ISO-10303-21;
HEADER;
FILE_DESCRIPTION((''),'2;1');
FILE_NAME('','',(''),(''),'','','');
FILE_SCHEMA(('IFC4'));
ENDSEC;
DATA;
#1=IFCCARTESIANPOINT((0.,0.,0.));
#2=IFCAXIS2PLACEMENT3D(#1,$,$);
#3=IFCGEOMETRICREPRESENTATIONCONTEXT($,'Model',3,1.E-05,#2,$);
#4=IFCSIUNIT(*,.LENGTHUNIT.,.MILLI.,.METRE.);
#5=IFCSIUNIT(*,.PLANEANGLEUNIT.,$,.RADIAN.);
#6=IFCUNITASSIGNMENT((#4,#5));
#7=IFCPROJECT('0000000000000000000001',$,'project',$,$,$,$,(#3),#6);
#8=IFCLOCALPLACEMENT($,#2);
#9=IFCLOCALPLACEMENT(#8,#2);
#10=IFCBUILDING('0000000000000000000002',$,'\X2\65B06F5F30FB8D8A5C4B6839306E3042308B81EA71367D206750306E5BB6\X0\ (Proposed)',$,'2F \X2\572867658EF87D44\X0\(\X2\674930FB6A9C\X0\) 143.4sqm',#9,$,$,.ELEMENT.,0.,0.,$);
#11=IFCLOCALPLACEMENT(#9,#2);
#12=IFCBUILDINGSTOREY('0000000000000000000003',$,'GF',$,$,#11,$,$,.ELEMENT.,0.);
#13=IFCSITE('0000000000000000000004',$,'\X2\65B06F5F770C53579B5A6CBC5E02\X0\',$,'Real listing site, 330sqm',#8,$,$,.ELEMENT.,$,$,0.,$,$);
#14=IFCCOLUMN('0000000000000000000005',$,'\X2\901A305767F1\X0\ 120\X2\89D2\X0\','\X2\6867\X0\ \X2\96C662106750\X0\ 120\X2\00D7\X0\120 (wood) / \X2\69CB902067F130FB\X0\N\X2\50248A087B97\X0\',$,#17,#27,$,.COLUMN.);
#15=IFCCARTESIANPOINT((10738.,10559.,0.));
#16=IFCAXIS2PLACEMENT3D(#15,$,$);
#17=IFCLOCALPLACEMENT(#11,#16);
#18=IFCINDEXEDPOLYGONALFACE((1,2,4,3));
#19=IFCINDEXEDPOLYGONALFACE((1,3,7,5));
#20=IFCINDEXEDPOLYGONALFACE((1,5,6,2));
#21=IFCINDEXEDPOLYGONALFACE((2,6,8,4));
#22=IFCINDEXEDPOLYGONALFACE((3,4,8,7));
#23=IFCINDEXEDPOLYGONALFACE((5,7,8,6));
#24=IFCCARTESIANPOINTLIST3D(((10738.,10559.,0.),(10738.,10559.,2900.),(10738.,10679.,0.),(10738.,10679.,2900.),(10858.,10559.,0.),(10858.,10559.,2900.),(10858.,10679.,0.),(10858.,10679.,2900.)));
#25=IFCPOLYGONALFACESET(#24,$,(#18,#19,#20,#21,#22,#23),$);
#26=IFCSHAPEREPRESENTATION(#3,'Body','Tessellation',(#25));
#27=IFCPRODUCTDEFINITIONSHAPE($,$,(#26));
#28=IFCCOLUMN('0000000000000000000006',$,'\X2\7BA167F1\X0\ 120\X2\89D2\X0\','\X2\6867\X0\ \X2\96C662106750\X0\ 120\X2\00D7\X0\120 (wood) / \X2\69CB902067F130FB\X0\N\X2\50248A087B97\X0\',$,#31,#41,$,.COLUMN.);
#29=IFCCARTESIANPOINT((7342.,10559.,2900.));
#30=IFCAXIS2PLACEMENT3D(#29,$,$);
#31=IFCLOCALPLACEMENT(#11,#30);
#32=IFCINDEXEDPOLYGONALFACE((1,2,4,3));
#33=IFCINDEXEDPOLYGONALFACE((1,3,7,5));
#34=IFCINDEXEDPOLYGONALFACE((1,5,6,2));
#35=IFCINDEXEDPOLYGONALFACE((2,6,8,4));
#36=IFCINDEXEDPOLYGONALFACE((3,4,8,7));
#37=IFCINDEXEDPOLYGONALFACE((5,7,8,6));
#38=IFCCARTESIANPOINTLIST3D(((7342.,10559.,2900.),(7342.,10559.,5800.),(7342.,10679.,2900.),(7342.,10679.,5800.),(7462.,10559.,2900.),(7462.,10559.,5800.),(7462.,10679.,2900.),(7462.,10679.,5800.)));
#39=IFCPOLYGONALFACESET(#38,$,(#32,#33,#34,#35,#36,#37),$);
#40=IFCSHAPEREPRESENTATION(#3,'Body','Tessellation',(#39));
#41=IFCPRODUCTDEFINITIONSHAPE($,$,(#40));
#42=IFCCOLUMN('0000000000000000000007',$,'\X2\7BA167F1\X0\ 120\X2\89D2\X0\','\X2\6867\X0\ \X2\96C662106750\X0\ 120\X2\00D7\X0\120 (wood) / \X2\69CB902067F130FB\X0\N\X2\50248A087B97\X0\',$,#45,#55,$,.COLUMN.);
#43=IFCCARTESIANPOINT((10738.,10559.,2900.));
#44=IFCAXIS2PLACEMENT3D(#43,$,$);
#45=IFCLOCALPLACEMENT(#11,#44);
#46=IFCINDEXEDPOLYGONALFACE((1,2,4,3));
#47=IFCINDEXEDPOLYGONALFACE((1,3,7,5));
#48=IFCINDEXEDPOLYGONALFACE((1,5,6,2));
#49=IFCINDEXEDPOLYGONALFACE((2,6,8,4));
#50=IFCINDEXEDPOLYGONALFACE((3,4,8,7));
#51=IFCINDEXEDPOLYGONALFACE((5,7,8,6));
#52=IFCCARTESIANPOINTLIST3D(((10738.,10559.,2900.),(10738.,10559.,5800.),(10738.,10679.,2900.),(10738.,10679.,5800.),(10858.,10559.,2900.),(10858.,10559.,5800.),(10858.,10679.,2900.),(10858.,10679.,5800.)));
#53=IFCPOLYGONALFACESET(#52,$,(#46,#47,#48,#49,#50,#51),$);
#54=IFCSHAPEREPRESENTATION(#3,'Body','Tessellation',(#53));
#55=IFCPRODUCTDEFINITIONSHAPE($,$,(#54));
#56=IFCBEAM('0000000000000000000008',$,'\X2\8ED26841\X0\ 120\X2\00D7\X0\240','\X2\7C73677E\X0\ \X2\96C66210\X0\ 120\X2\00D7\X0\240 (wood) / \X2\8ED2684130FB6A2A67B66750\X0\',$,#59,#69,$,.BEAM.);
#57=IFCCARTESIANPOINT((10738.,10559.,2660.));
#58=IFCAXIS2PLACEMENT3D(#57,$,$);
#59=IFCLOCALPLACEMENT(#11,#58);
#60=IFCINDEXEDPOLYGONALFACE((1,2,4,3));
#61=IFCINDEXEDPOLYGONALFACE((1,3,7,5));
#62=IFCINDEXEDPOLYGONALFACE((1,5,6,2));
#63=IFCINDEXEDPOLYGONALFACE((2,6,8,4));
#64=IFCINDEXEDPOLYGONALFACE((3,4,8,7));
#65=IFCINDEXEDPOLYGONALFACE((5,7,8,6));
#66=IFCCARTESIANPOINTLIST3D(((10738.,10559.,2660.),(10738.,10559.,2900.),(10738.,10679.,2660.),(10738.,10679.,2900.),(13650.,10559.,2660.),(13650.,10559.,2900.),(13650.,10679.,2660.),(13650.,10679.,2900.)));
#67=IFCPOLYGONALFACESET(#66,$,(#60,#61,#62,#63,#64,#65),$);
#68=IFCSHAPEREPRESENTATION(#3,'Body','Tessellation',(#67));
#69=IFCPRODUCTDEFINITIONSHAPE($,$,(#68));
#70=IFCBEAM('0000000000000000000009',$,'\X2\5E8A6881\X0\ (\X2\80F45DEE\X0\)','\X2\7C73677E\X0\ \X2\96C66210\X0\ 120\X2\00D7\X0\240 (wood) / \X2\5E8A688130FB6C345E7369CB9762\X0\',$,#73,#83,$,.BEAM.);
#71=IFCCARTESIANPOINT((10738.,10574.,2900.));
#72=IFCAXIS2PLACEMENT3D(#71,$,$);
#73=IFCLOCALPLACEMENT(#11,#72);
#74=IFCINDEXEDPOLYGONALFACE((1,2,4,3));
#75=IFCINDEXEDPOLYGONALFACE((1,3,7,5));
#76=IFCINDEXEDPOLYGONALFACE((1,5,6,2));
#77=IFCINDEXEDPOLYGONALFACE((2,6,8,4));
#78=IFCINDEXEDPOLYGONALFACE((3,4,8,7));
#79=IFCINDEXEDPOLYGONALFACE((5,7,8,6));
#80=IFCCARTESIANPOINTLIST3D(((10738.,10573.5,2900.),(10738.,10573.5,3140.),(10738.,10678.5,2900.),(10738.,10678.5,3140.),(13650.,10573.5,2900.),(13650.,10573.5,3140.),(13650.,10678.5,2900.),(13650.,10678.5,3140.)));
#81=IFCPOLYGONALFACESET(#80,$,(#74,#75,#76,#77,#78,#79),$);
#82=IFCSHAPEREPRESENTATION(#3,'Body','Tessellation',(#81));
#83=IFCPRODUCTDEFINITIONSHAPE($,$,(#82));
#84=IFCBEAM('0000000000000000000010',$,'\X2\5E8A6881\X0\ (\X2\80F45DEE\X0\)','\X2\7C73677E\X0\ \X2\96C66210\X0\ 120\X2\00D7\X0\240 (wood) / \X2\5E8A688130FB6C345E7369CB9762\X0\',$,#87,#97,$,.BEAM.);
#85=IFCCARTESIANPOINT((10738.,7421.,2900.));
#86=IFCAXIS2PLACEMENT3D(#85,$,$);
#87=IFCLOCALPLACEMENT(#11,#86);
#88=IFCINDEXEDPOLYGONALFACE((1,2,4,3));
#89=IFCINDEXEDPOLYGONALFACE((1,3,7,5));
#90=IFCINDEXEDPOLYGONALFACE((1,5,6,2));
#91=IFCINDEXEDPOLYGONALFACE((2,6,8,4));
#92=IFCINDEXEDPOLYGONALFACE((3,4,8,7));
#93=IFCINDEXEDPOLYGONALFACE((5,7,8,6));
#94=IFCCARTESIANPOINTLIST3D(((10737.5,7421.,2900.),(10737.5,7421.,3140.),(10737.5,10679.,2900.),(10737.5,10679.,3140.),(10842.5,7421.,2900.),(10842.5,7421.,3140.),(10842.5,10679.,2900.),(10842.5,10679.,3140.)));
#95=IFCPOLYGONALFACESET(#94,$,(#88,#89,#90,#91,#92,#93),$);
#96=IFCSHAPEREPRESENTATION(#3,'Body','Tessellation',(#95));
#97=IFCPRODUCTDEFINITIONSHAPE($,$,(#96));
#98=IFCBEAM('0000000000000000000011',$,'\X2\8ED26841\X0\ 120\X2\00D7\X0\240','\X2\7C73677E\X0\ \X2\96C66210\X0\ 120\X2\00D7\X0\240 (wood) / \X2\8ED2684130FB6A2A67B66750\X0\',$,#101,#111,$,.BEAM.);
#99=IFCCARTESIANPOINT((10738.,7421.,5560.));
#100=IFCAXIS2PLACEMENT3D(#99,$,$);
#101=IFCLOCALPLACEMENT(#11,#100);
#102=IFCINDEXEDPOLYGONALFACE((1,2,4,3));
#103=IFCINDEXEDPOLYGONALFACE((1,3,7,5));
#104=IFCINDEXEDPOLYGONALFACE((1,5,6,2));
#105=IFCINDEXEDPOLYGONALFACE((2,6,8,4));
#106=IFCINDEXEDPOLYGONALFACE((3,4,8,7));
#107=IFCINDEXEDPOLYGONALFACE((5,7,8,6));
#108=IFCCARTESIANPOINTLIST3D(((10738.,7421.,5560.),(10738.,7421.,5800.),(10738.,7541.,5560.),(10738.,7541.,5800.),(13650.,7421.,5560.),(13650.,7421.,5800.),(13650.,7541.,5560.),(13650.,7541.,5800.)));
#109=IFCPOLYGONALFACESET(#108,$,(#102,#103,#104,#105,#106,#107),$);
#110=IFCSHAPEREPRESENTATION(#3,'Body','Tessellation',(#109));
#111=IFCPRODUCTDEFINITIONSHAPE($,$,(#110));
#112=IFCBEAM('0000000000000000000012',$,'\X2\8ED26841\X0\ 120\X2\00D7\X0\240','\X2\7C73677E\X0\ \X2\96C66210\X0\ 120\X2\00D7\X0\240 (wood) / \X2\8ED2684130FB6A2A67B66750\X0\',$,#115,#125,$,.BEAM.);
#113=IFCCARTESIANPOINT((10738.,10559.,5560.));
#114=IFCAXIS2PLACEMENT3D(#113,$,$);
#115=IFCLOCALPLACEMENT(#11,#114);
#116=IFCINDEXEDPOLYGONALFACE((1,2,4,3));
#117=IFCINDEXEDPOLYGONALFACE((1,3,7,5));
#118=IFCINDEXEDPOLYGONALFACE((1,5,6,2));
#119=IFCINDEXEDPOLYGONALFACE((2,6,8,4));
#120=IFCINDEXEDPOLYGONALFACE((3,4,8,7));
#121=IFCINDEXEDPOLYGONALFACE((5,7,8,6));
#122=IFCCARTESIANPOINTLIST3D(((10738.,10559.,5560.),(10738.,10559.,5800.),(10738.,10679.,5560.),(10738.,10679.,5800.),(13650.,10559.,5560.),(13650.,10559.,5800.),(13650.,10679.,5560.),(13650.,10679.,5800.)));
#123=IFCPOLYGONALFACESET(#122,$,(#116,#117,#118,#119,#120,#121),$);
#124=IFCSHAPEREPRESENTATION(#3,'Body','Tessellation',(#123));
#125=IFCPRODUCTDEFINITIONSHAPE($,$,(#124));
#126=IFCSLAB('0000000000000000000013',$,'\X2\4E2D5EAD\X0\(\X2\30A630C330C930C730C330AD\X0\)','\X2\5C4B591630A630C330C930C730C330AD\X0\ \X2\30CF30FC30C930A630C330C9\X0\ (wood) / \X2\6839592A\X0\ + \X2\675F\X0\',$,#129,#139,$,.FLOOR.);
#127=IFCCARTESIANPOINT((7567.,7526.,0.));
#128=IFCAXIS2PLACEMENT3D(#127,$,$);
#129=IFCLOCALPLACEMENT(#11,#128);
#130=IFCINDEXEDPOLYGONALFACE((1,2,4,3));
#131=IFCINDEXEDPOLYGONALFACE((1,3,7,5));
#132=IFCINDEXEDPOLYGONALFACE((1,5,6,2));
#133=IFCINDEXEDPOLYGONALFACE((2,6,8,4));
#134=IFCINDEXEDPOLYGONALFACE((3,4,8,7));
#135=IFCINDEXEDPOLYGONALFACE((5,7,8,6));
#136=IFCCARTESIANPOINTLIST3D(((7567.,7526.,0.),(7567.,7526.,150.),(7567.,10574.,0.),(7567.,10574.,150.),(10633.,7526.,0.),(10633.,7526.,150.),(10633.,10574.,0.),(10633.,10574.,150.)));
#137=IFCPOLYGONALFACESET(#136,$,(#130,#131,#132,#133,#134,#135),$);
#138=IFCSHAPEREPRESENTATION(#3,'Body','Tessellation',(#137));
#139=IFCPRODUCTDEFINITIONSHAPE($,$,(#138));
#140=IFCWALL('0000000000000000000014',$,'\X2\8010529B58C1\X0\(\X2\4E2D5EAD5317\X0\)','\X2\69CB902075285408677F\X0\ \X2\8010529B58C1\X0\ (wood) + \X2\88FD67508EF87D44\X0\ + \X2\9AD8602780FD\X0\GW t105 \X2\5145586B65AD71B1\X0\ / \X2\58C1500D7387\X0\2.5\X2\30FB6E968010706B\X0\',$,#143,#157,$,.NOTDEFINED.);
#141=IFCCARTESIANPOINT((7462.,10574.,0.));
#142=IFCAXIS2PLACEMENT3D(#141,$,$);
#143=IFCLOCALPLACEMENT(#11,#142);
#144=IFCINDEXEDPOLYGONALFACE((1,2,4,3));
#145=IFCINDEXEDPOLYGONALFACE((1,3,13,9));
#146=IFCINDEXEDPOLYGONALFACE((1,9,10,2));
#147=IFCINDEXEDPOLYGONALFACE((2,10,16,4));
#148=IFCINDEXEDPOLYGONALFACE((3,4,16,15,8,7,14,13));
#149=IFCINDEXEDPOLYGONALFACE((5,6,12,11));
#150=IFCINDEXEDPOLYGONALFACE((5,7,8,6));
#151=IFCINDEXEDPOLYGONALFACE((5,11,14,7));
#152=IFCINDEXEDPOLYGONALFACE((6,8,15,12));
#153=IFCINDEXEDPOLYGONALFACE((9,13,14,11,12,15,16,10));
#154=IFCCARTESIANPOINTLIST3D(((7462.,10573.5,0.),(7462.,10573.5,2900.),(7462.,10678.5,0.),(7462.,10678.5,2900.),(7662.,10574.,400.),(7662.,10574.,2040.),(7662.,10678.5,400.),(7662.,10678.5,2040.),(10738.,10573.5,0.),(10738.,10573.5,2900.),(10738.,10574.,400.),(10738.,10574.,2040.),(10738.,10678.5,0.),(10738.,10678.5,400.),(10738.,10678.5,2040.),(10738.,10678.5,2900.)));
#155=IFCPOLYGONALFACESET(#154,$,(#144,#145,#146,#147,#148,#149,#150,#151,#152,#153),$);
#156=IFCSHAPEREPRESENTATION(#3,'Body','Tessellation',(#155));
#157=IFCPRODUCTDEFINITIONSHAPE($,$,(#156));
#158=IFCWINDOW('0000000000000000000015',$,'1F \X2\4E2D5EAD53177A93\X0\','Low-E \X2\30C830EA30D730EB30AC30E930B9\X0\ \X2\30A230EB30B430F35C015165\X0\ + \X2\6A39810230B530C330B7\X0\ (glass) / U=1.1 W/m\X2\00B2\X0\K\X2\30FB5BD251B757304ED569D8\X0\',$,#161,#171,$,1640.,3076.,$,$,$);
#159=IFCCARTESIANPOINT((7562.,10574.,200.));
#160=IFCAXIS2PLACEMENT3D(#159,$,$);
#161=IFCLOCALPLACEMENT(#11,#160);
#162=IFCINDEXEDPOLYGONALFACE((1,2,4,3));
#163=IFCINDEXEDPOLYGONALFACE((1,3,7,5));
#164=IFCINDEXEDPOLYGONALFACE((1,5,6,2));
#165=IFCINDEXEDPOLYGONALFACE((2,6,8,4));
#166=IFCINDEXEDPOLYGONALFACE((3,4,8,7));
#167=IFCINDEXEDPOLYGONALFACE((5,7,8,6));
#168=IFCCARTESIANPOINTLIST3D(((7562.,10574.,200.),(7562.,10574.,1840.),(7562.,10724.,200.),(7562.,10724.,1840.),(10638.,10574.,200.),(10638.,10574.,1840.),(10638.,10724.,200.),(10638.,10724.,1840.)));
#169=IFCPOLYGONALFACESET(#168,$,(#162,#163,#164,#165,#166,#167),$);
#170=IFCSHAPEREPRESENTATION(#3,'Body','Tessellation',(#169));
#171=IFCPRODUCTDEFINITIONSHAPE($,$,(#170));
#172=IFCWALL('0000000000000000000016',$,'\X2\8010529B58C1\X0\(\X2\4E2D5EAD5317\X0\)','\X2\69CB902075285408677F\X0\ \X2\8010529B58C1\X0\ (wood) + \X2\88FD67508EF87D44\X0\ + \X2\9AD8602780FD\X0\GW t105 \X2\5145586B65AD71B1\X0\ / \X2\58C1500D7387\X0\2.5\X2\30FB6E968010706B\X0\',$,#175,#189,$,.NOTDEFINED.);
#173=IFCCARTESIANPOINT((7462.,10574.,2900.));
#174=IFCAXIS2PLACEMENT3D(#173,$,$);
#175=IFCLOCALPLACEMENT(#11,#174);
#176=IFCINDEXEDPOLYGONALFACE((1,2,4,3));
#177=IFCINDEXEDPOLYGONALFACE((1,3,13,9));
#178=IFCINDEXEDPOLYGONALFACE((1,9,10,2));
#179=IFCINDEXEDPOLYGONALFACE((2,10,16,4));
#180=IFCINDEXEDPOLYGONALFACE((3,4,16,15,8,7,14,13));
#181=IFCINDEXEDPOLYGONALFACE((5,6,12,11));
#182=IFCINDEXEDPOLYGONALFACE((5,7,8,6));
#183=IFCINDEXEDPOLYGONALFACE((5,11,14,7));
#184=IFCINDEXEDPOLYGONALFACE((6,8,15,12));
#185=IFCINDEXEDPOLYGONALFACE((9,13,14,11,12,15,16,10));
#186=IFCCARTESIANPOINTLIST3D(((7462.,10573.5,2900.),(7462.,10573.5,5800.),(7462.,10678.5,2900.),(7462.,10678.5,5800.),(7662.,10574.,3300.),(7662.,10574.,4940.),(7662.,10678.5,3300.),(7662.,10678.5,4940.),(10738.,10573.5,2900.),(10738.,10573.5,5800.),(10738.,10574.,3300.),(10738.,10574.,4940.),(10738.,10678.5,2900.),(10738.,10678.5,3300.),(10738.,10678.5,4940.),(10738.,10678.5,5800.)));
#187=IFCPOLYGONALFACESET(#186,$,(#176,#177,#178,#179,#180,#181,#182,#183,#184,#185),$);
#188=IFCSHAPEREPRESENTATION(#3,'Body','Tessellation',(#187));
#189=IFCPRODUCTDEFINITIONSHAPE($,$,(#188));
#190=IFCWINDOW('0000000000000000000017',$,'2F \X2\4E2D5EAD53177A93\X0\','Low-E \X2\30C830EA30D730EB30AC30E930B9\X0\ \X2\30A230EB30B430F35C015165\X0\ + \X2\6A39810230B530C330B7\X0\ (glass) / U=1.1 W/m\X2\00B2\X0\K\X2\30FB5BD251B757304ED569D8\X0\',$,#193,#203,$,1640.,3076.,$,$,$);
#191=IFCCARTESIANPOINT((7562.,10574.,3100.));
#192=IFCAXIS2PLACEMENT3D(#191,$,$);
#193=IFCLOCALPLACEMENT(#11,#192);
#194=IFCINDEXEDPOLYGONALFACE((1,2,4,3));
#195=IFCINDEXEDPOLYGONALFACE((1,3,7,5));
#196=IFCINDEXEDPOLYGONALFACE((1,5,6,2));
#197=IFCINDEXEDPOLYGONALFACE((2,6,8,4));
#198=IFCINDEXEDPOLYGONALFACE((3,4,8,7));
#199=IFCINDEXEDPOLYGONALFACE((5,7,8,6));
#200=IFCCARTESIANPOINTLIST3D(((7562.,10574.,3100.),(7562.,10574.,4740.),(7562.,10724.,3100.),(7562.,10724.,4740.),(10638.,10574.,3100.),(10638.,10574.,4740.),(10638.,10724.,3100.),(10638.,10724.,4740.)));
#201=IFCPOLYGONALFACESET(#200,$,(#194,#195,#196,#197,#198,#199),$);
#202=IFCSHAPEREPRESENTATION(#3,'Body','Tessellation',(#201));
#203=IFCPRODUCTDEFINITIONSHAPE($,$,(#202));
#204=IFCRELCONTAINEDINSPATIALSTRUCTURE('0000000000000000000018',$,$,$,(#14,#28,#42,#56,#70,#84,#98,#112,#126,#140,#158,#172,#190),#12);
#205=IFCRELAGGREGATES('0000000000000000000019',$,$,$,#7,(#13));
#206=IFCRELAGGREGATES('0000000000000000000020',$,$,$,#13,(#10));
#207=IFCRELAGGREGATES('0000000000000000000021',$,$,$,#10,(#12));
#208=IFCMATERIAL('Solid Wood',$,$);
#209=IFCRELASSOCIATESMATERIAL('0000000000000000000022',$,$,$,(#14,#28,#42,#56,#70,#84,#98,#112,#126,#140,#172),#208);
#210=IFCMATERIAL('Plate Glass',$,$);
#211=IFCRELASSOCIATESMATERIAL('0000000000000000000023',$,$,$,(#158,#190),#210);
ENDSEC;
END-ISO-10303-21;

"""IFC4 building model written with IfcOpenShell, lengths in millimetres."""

from ifc_helpers import new_model, si_unit, frame, frame_2d, origin, place, context, project, spatial, rectangle, extrude, material, element, fill, save


model = new_model("IFC4")

# Units and contexts
model_context = context("Model", 3, precision=1e-05, world=origin())
ifc_project = project(units=[si_unit("LENGTHUNIT", "METRE", prefix="MILLI"), si_unit("PLANEANGLEUNIT", "RADIAN")], contexts=[model_context])

# Site, building, storey
site_placement = place(None, origin())
site = spatial("IfcSite", under=ifc_project, at=site_placement, Name="新潟県南魚沼市", ObjectType="Real listing site, 330sqm", CompositionType="ELEMENT", RefElevation=0.0)
building_placement = place(site_placement, origin())
building = spatial("IfcBuilding", under=site, at=building_placement, Name="新潟・越屋根のある自然素材の家 (Proposed)", ObjectType="2F 在来軸組(杉・檜) 143.4sqm", CompositionType="ELEMENT", ElevationOfRefHeight=0.0, ElevationOfTerrain=0.0)
storey_placement = place(building_placement, origin())
storey = spatial("IfcBuildingStorey", under=building, at=storey_placement, Name="GF", CompositionType="ELEMENT", Elevation=0.0)

# Columns
ifc_material_1 = material(Name="Solid Wood")
column_1_placement = place(storey_placement, frame((10738.0, 10559.0, 0.0)))
element("IfcColumn", 1, at=column_1_placement, inside=storey, material=ifc_material_1, Name="通し柱 120角", Description="桧 集成材 120×120 (wood) / 構造柱・N値計算", PredefinedType="COLUMN", context=model_context, shape_type="SweptSolid", body=[
    extrude(rectangle(XDim=120.0, YDim=120.0, at=frame_2d((60.0, 60.0))), frame((10738.0, 10559.0, 0.0)), (0.0, 0.0, 1.0), 2900.0),
])
column_2_placement = place(storey_placement, frame((7342.0, 10559.0, 2900.0)))
element("IfcColumn", 2, at=column_2_placement, inside=storey, material=ifc_material_1, Name="管柱 120角", Description="桧 集成材 120×120 (wood) / 構造柱・N値計算", PredefinedType="COLUMN", context=model_context, shape_type="SweptSolid", body=[
    extrude(rectangle(XDim=120.0, YDim=120.0, at=frame_2d((60.0, 60.0))), frame((7342.0, 10559.0, 2900.0)), (0.0, 0.0, 1.0), 2900.0),
])
column_3_placement = place(storey_placement, frame((10738.0, 10559.0, 2900.0)))
element("IfcColumn", 3, at=column_3_placement, inside=storey, material=ifc_material_1, Name="管柱 120角", Description="桧 集成材 120×120 (wood) / 構造柱・N値計算", PredefinedType="COLUMN", context=model_context, shape_type="SweptSolid", body=[
    extrude(rectangle(XDim=120.0, YDim=120.0, at=frame_2d((60.0, 60.0))), frame((10738.0, 10559.0, 2900.0)), (0.0, 0.0, 1.0), 2900.0),
])

# Beams
beam_1_placement = place(storey_placement, frame((10738.0, 10559.0, 2660.0)))
element("IfcBeam", 4, at=beam_1_placement, inside=storey, material=ifc_material_1, Name="軒桁 120×240", Description="米松 集成 120×240 (wood) / 軒桁・横架材", PredefinedType="BEAM", context=model_context, shape_type="SweptSolid", body=[
    extrude(rectangle(XDim=2912.0, YDim=120.0, at=frame_2d((1456.0, 60.0))), frame((10738.0, 10559.0, 2660.0)), (0.0, 0.0, 1.0), 240.0),
])
beam_2_placement = place(storey_placement, frame((10738.0, 10574.0, 2900.0)))
element("IfcBeam", 5, at=beam_2_placement, inside=storey, material=ifc_material_1, Name="床梁 (胴差)", Description="米松 集成 120×240 (wood) / 床梁・水平構面", PredefinedType="BEAM", context=model_context, shape_type="SweptSolid", body=[
    extrude(rectangle(XDim=2912.0, YDim=105.0, at=frame_2d((1456.0, 52.0))), frame((10738.0, 10574.0, 2900.0)), (0.0, 0.0, 1.0), 240.0),
])
beam_3_placement = place(storey_placement, frame((10738.0, 7421.0, 2900.0)))
element("IfcBeam", 6, at=beam_3_placement, inside=storey, material=ifc_material_1, Name="床梁 (胴差)", Description="米松 集成 120×240 (wood) / 床梁・水平構面", PredefinedType="BEAM", context=model_context, shape_type="SweptSolid", body=[
    extrude(rectangle(XDim=105.0, YDim=3258.0, at=frame_2d((52.0, 1629.0))), frame((10738.0, 7421.0, 2900.0)), (0.0, 0.0, 1.0), 240.0),
])
beam_4_placement = place(storey_placement, frame((10738.0, 7421.0, 5560.0)))
element("IfcBeam", 7, at=beam_4_placement, inside=storey, material=ifc_material_1, Name="軒桁 120×240", Description="米松 集成 120×240 (wood) / 軒桁・横架材", PredefinedType="BEAM", context=model_context, shape_type="SweptSolid", body=[
    extrude(rectangle(XDim=2912.0, YDim=120.0, at=frame_2d((1456.0, 60.0))), frame((10738.0, 7421.0, 5560.0)), (0.0, 0.0, 1.0), 240.0),
])
beam_5_placement = place(storey_placement, frame((10738.0, 10559.0, 5560.0)))
element("IfcBeam", 8, at=beam_5_placement, inside=storey, material=ifc_material_1, Name="軒桁 120×240", Description="米松 集成 120×240 (wood) / 軒桁・横架材", PredefinedType="BEAM", context=model_context, shape_type="SweptSolid", body=[
    extrude(rectangle(XDim=2912.0, YDim=120.0, at=frame_2d((1456.0, 60.0))), frame((10738.0, 10559.0, 5560.0)), (0.0, 0.0, 1.0), 240.0),
])

# Slab
slab_placement = place(storey_placement, frame((7567.0, 7526.0, 0.0)))
element("IfcSlab", 9, at=slab_placement, inside=storey, material=ifc_material_1, Name="中庭(ウッドデッキ)", Description="屋外ウッドデッキ ハードウッド (wood) / 根太 + 束", PredefinedType="FLOOR", context=model_context, shape_type="SweptSolid", body=[
    extrude(rectangle(XDim=3066.0, YDim=3048.0, at=frame_2d((1533.0, 1524.0))), frame((7567.0, 7526.0, 0.0)), (0.0, 0.0, 1.0), 150.0),
])

# Wall, opening, window
wall_1_placement = place(storey_placement, frame((7462.0, 10574.0, 0.0)))
wall_1 = element("IfcWall", 10, at=wall_1_placement, inside=storey, material=ifc_material_1, Name="耐力壁(中庭北)", Description="構造用合板 耐力壁 (wood) + 製材軸組 + 高性能GW t105 充填断熱 / 壁倍率2.5・準耐火", PredefinedType="NOTDEFINED", context=model_context, shape_type="SweptSolid", body=[
    extrude(rectangle(XDim=3276.0, YDim=105.0, at=frame_2d((1638.0, 52.0))), frame((7462.0, 10574.0, 0.0)), (0.0, 0.0, 1.0), 2900.0),
])
opening_1_placement = place(storey_placement, frame((7562.0, 10574.0, 200.0)))
opening_1 = element("IfcOpeningElement", 11, at=opening_1_placement, cuts=wall_1, PredefinedType="NOTDEFINED", context=model_context, shape_type="SweptSolid", body=[
    extrude(rectangle(XDim=3076.0, YDim=150.0, at=frame_2d((1538.0, 75.0))), frame((7562.0, 10574.0, 200.0)), (0.0, 0.0, 1.0), 1640.0),
])
ifc_material_2 = material(Name="Plate Glass")
window_1_placement = place(storey_placement, frame((7562.0, 10574.0, 200.0)))
window_1 = element("IfcWindow", 12, at=window_1_placement, inside=storey, material=ifc_material_2, Name="1F 中庭北窓", Description="Low-E トリプルガラス アルゴン封入 + 樹脂サッシ (glass) / U=1.1 W/m²K・寒冷地仕様", OverallHeight=1640.0, OverallWidth=3076.0, context=model_context, shape_type="SweptSolid", body=[
    extrude(rectangle(XDim=3076.0, YDim=150.0, at=frame_2d((1538.0, 75.0))), frame((7562.0, 10574.0, 200.0)), (0.0, 0.0, 1.0), 1640.0),
])
fill(opening_1, window_1)

# Wall, opening, window
wall_2_placement = place(storey_placement, frame((7462.0, 10574.0, 2900.0)))
wall_2 = element("IfcWall", 13, at=wall_2_placement, inside=storey, material=ifc_material_1, Name="耐力壁(中庭北)", Description="構造用合板 耐力壁 (wood) + 製材軸組 + 高性能GW t105 充填断熱 / 壁倍率2.5・準耐火", PredefinedType="NOTDEFINED", context=model_context, shape_type="SweptSolid", body=[
    extrude(rectangle(XDim=3276.0, YDim=105.0, at=frame_2d((1638.0, 52.0))), frame((7462.0, 10574.0, 2900.0)), (0.0, 0.0, 1.0), 2900.0),
])
opening_2_placement = place(storey_placement, frame((7562.0, 10574.0, 3100.0)))
opening_2 = element("IfcOpeningElement", 14, at=opening_2_placement, cuts=wall_2, PredefinedType="NOTDEFINED", context=model_context, shape_type="SweptSolid", body=[
    extrude(rectangle(XDim=3076.0, YDim=150.0, at=frame_2d((1538.0, 75.0))), frame((7562.0, 10574.0, 3100.0)), (0.0, 0.0, 1.0), 1640.0),
])
window_2_placement = place(storey_placement, frame((7562.0, 10574.0, 3100.0)))
window_2 = element("IfcWindow", 15, at=window_2_placement, inside=storey, material=ifc_material_2, Name="2F 中庭北窓", Description="Low-E トリプルガラス アルゴン封入 + 樹脂サッシ (glass) / U=1.1 W/m²K・寒冷地仕様", OverallHeight=1640.0, OverallWidth=3076.0, context=model_context, shape_type="SweptSolid", body=[
    extrude(rectangle(XDim=3076.0, YDim=150.0, at=frame_2d((1538.0, 75.0))), frame((7562.0, 10574.0, 3100.0)), (0.0, 0.0, 1.0), 1640.0),
])
fill(opening_2, window_2)

save(model, "model.ifc")
